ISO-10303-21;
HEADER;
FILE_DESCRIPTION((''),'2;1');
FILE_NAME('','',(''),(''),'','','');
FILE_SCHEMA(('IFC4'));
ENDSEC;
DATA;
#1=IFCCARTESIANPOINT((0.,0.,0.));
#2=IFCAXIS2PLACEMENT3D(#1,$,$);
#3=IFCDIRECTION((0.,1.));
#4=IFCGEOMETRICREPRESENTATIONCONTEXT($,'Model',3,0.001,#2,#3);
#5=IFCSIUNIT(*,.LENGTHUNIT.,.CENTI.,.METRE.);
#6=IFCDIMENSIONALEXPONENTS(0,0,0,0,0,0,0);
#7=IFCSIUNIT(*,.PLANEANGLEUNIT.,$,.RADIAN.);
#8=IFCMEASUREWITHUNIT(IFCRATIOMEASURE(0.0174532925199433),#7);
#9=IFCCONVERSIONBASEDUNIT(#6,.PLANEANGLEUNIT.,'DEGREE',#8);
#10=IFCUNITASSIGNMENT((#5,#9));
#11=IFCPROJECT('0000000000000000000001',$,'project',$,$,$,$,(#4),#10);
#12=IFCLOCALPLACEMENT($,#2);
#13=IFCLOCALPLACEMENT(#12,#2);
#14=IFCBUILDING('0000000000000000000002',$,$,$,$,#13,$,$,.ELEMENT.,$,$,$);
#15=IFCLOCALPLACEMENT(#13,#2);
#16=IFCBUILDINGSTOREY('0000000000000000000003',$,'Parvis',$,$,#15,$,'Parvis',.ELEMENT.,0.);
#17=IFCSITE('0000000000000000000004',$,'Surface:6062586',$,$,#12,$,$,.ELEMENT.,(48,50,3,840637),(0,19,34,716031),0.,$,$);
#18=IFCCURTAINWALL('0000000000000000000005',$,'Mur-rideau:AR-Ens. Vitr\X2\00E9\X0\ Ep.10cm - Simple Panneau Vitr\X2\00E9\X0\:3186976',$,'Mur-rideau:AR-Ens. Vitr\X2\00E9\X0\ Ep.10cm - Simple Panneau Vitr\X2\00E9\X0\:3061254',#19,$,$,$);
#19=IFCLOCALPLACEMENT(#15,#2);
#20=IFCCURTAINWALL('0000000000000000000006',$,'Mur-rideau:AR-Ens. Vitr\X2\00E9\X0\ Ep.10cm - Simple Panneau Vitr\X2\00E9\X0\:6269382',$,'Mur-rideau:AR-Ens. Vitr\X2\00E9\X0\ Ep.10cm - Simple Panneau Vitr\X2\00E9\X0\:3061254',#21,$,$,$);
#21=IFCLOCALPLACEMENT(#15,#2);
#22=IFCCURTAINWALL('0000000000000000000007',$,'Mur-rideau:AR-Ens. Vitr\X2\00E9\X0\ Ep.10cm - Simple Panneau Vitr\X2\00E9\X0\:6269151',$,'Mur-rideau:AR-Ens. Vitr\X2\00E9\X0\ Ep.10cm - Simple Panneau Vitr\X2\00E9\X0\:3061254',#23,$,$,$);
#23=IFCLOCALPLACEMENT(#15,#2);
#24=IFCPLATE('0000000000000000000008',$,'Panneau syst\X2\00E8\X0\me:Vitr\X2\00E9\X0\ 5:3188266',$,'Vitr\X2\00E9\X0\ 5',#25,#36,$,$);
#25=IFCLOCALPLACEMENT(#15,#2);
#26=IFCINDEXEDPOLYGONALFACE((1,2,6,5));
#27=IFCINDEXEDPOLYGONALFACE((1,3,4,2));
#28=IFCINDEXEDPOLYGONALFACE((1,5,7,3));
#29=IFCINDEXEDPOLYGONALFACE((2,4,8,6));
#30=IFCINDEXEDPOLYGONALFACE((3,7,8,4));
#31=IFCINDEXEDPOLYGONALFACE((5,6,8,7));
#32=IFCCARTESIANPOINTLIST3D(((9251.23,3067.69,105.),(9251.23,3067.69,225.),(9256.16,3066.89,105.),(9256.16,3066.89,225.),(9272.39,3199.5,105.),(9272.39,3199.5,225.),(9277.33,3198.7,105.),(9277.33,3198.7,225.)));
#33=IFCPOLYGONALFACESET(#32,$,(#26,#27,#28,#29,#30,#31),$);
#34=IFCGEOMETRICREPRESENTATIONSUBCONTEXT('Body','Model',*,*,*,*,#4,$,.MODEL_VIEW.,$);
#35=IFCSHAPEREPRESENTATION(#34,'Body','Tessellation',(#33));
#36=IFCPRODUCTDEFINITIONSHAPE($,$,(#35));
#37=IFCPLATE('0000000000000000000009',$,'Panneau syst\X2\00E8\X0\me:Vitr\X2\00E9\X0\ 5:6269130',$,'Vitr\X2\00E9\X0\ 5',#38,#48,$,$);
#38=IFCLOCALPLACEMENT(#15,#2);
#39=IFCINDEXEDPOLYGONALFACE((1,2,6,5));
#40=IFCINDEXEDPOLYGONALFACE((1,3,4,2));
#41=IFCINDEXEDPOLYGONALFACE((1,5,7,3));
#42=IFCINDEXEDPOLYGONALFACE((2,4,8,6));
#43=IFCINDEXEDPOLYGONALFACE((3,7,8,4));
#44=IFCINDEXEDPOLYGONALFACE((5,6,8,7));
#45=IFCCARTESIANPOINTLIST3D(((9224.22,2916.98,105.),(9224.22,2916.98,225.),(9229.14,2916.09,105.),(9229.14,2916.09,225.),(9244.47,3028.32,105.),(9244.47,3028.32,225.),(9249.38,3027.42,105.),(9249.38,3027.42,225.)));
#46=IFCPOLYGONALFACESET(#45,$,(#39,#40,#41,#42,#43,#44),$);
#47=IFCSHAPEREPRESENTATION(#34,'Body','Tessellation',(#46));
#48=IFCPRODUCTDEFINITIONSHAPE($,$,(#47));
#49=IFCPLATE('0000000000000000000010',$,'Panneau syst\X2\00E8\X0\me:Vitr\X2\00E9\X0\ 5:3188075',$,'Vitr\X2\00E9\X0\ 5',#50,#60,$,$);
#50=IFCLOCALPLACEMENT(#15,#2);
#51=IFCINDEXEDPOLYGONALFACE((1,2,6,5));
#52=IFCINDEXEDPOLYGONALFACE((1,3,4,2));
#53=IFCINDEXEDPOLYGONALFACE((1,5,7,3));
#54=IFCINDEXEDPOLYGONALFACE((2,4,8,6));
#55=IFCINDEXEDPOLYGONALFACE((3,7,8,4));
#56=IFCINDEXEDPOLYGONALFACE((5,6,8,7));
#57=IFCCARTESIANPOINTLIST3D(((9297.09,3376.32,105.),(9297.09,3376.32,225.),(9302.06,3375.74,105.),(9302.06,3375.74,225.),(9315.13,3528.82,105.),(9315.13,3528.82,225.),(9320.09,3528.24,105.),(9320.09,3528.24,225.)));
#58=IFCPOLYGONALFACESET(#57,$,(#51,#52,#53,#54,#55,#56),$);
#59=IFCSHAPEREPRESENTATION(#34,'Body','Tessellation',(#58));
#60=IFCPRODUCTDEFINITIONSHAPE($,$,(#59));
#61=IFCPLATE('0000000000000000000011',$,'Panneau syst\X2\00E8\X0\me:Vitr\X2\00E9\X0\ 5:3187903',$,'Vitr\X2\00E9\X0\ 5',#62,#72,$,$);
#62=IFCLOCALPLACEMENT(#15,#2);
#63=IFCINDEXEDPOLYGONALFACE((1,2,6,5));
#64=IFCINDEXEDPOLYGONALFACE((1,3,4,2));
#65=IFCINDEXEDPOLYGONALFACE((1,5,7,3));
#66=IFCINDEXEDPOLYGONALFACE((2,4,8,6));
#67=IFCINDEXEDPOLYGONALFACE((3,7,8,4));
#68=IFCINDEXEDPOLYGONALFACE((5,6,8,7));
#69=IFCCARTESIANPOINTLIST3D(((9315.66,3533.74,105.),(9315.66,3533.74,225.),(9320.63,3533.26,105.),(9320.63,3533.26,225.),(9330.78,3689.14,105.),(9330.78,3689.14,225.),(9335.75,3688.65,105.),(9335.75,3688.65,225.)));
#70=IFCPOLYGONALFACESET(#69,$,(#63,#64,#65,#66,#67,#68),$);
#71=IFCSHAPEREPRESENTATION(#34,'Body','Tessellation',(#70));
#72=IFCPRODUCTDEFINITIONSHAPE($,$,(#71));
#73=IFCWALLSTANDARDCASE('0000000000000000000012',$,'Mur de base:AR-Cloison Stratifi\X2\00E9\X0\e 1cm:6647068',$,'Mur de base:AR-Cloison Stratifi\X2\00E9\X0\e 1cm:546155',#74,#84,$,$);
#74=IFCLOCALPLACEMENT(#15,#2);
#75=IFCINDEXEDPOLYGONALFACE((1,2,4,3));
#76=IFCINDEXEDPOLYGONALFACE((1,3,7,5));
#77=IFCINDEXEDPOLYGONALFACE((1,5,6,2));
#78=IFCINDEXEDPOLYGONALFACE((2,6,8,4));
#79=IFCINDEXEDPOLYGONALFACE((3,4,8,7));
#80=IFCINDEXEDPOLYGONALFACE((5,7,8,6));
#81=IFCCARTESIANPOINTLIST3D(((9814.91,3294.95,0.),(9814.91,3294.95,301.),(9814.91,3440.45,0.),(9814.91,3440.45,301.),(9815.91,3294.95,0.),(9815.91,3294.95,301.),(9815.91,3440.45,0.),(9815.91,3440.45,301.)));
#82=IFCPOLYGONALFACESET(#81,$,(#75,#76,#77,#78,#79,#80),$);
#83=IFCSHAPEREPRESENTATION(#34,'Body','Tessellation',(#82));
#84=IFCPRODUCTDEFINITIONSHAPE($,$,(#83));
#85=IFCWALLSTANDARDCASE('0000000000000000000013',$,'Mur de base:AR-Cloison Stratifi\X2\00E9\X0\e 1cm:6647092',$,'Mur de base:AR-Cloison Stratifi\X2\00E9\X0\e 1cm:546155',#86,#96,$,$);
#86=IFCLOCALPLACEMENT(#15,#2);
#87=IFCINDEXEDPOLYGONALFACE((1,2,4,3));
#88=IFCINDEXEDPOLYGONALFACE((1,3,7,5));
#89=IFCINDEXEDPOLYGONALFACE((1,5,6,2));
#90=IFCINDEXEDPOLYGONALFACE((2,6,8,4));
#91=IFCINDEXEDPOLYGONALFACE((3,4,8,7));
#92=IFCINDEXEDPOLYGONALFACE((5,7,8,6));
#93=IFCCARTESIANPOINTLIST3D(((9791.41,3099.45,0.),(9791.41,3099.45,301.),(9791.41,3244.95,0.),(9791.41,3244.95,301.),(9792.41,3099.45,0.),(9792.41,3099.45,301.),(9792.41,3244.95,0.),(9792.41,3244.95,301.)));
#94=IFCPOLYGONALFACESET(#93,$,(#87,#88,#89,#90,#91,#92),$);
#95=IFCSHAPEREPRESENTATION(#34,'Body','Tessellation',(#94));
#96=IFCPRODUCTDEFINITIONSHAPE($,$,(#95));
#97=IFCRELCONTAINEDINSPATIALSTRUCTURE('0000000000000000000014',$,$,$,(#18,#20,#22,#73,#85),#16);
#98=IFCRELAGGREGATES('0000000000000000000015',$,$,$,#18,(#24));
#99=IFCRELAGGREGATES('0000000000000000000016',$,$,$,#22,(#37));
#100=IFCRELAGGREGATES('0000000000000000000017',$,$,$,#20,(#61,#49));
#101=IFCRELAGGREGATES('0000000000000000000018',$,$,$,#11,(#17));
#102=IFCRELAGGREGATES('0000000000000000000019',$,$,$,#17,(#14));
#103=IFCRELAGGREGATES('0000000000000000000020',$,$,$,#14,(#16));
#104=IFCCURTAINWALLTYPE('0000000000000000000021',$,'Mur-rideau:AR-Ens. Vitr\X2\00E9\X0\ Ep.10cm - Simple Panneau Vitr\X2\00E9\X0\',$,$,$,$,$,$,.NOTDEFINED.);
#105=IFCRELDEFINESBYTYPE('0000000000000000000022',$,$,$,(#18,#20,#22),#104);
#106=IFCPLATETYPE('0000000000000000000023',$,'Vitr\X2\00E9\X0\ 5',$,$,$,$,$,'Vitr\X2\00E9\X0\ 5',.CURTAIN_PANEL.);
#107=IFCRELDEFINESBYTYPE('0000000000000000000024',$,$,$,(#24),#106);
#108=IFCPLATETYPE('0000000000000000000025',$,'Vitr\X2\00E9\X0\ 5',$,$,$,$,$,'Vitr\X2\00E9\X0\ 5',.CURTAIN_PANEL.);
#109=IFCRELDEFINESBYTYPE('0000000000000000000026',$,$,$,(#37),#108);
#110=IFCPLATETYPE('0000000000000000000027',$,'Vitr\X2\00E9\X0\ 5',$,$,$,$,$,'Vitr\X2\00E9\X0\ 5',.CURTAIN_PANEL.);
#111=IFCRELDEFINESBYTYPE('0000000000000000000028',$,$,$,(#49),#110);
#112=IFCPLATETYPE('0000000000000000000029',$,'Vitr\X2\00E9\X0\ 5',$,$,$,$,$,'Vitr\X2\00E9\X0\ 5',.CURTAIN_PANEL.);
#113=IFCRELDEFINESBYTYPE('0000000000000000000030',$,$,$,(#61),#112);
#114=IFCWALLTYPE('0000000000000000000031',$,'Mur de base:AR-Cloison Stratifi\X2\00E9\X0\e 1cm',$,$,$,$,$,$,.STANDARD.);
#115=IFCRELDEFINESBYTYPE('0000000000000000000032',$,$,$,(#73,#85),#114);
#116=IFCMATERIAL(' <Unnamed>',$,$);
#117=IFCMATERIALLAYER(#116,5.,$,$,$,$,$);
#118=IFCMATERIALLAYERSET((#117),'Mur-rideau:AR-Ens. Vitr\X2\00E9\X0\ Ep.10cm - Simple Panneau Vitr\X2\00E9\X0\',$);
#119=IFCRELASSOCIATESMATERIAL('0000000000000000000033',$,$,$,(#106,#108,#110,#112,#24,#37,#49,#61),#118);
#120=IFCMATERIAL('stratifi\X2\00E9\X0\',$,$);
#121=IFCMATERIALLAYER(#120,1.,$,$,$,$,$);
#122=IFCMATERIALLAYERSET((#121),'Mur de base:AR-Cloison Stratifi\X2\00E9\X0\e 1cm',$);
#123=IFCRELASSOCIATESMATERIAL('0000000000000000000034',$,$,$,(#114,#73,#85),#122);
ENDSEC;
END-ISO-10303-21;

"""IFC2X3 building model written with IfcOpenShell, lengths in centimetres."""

from ifc_helpers import new_model, entity, si_unit, converted_unit, direction, frame, frame_2d, origin, place, context, subcontext, project, spatial, rectangle, extrude, source, transform, mapped, material, layer, layer_set, layer_usage, type_object, type_shapes, element, aggregate, save


model = new_model("IFC2X3")

# Units and contexts
model_context = context("Model", 3, precision=0.001, world=origin(), true_north=direction((0.0, 1.0)))
body_context = subcontext(model_context, "Body", "Model", "MODEL_VIEW")
ifc_project = project(units=[si_unit("LENGTHUNIT", "METRE", prefix="CENTI"), converted_unit("PLANEANGLEUNIT", "DEGREE", entity("IfcRatioMeasure", 0.0174532925199433), si_unit("PLANEANGLEUNIT", "RADIAN"), dimensions=[0, 0, 0, 0, 0, 0, 0])], contexts=[model_context])

# Site, building, storey
site_placement = place(None, origin())
site = spatial("IfcSite", under=ifc_project, at=site_placement, Name="Surface:6062586", CompositionType="ELEMENT", RefLatitude=(48, 50, 3, 840637), RefLongitude=(0, 19, 34, 716031), RefElevation=0.0)
building_placement = place(site_placement, origin())
building = spatial("IfcBuilding", under=site, at=building_placement, CompositionType="ELEMENT")
storey_placement = place(building_placement, frame((0.0, 0.0, 0.0)))
storey = spatial("IfcBuildingStorey", under=building, at=storey_placement, Name="Parvis", LongName="Parvis", CompositionType="ELEMENT", Elevation=0.0)

# Curtain walls
curtain_wall_type = type_object("IfcCurtainWallType", Name="Mur-rideau:AR-Ens. Vitré Ep.10cm - Simple Panneau Vitré", PredefinedType="NOTDEFINED")
curtain_wall_1_placement = place(storey_placement, frame((0.0, 0.0, 0.0)))
curtain_wall_1 = element("IfcCurtainWall", 1, at=curtain_wall_1_placement, inside=storey, type_object=curtain_wall_type, Name="Mur-rideau:AR-Ens. Vitré Ep.10cm - Simple Panneau Vitré:3186976", ObjectType="Mur-rideau:AR-Ens. Vitré Ep.10cm - Simple Panneau Vitré:3061254")
curtain_wall_2_placement = place(storey_placement, frame((0.0, 0.0, 0.0)))
curtain_wall_2 = element("IfcCurtainWall", 2, at=curtain_wall_2_placement, inside=storey, type_object=curtain_wall_type, Name="Mur-rideau:AR-Ens. Vitré Ep.10cm - Simple Panneau Vitré:6269382", ObjectType="Mur-rideau:AR-Ens. Vitré Ep.10cm - Simple Panneau Vitré:3061254")

# Curtain wall
curtain_wall_3_placement = place(storey_placement, frame((0.0, 0.0, 0.0)))
curtain_wall_3 = element("IfcCurtainWall", 3, at=curtain_wall_3_placement, inside=storey, type_object=curtain_wall_type, Name="Mur-rideau:AR-Ens. Vitré Ep.10cm - Simple Panneau Vitré:6269151", ObjectType="Mur-rideau:AR-Ens. Vitré Ep.10cm - Simple Panneau Vitré:3061254")

# Plates
ifc_material_1 = material(Name=" <Unnamed>")
ifc_layer_1 = layer(ifc_material_1, 5.0)
ifc_layer_set_1 = layer_set([ifc_layer_1], Name="Mur-rideau:AR-Ens. Vitré Ep.10cm - Simple Panneau Vitré")
ifc_layer_usage_1 = layer_usage(ifc_layer_set_1, "AXIS3", "POSITIVE", 0.0)
plate_type_1 = type_object("IfcPlateType", Name="Vitré 5", ElementType="Vitré 5", PredefinedType="CURTAIN_PANEL", material=ifc_layer_set_1)
shared_shape_1 = source(origin(), body_context, "Body", "SweptSolid", [
    extrude(rectangle(XDim=5.0, YDim=133.5, at=frame_2d((0.0, 0.0), x_axis=(1.0, 0.0))), frame((0.0, 0.0, 0.0), z_axis=(0.0, 0.0, 1.0), x_axis=(0.0, 1.0, 0.0)), (0.0, 0.0, 1.0), 120.0),
])
type_shapes(plate_type_1, [shared_shape_1])
plate_1_placement = place(curtain_wall_1_placement, frame((9264.28, 3133.2, 105.0), z_axis=(0.0, 0.0, 1.0), x_axis=(-0.158533, -0.987354, 0.0)))
plate_1 = element("IfcPlate", 4, at=plate_1_placement, type_object=plate_type_1, material=ifc_layer_usage_1, Name="Panneau système:Vitré 5:3188266", ObjectType="Vitré 5", context=body_context, shape_type="MappedRepresentation", body=[
    mapped(shared_shape_1, transform((0.0, 0.0, 0.0), scale=1.0)),
])
aggregate(curtain_wall_1, [plate_1])
ifc_layer_usage_2 = layer_usage(ifc_layer_set_1, "AXIS3", "POSITIVE", 0.0)
plate_type_2 = type_object("IfcPlateType", Name="Vitré 5", ElementType="Vitré 5", PredefinedType="CURTAIN_PANEL", material=ifc_layer_set_1)
shared_shape_2 = source(origin(), body_context, "Body", "SweptSolid", [
    extrude(rectangle(XDim=5.0, YDim=113.16, at=frame_2d((0.0, 0.0), x_axis=(1.0, 0.0))), frame((0.0, 0.0, 0.0), z_axis=(0.0, 0.0, 1.0), x_axis=(0.0, 1.0, 0.0)), (0.0, 0.0, 1.0), 120.0),
])
type_shapes(plate_type_2, [shared_shape_2])
plate_2_placement = place(curtain_wall_3_placement, frame((9236.8, 2972.2, 105.0), z_axis=(0.0, 0.0, 1.0), x_axis=(-0.17894, -0.98386, 0.0)))
plate_2 = element("IfcPlate", 5, at=plate_2_placement, type_object=plate_type_2, material=ifc_layer_usage_2, Name="Panneau système:Vitré 5:6269130", ObjectType="Vitré 5", context=body_context, shape_type="MappedRepresentation", body=[
    mapped(shared_shape_2, transform((0.0, 0.0, 0.0), scale=1.0)),
])
aggregate(curtain_wall_3, [plate_2])
ifc_layer_usage_3 = layer_usage(ifc_layer_set_1, "AXIS3", "POSITIVE", 0.0)
plate_type_3 = type_object("IfcPlateType", Name="Vitré 5", ElementType="Vitré 5", PredefinedType="CURTAIN_PANEL", material=ifc_layer_set_1)
shared_shape_3 = source(origin(), body_context, "Body", "SweptSolid", [
    extrude(rectangle(XDim=5.0, YDim=153.56, at=frame_2d((0.0, 0.0), x_axis=(1.0, 0.0))), frame((0.0, 0.0, 0.0), z_axis=(0.0, 0.0, 1.0), x_axis=(0.0, 1.0, 0.0)), (0.0, 0.0, 1.0), 120.0),
])
type_shapes(plate_type_3, [shared_shape_3])
plate_3_placement = place(curtain_wall_2_placement, frame((9308.59, 3452.28, 105.0), z_axis=(0.0, 0.0, 1.0), x_axis=(-0.117457, -0.993078, 0.0)))
plate_3 = element("IfcPlate", 6, at=plate_3_placement, type_object=plate_type_3, material=ifc_layer_usage_3, Name="Panneau système:Vitré 5:3188075", ObjectType="Vitré 5", context=body_context, shape_type="MappedRepresentation", body=[
    mapped(shared_shape_3, transform((0.0, 0.0, 0.0), scale=1.0)),
])
ifc_layer_usage_4 = layer_usage(ifc_layer_set_1, "AXIS3", "POSITIVE", 0.0)
plate_type_4 = type_object("IfcPlateType", Name="Vitré 5", ElementType="Vitré 5", PredefinedType="CURTAIN_PANEL", material=ifc_layer_set_1)
shared_shape_4 = source(origin(), body_context, "Body", "SweptSolid", [
    extrude(rectangle(XDim=5.0, YDim=156.13, at=frame_2d((0.0, 0.0), x_axis=(1.0, 0.0))), frame((0.0, 0.0, 0.0), z_axis=(0.0, 0.0, 1.0), x_axis=(0.0, 1.0, 0.0)), (0.0, 0.0, 1.0), 120.0),
])
type_shapes(plate_type_4, [shared_shape_4])
plate_4_placement = place(curtain_wall_2_placement, frame((9325.71, 3611.2, 105.0), z_axis=(0.0, 0.0, 1.0), x_axis=(-0.096838, -0.9953, 0.0)))
plate_4 = element("IfcPlate", 7, at=plate_4_placement, type_object=plate_type_4, material=ifc_layer_usage_4, Name="Panneau système:Vitré 5:3187903", ObjectType="Vitré 5", context=body_context, shape_type="MappedRepresentation", body=[
    mapped(shared_shape_4, transform((0.0, 0.0, 0.0), scale=1.0)),
])
aggregate(curtain_wall_2, [plate_4, plate_3])

# Walls
ifc_material_2 = material(Name="stratifié")
ifc_layer_2 = layer(ifc_material_2, 1.0)
ifc_layer_set_2 = layer_set([ifc_layer_2], Name="Mur de base:AR-Cloison Stratifiée 1cm")
ifc_layer_usage_5 = layer_usage(ifc_layer_set_2, "AXIS2", "NEGATIVE", 0.5)
wall_type_1 = type_object("IfcWallType", Name="Mur de base:AR-Cloison Stratifiée 1cm", PredefinedType="STANDARD", material=ifc_layer_set_2)
wall_1_placement = place(storey_placement, frame((9815.41, 3294.95, 0.0), z_axis=(0.0, 0.0, 1.0), x_axis=(0.0, 1.0, 0.0)))
element("IfcWallStandardCase", 8, at=wall_1_placement, inside=storey, type_object=wall_type_1, material=ifc_layer_usage_5, Name="Mur de base:AR-Cloison Stratifiée 1cm:6647068", ObjectType="Mur de base:AR-Cloison Stratifiée 1cm:546155", context=body_context, shape_type="SweptSolid", body=[
    extrude(rectangle(XDim=145.5, YDim=1.0, at=frame_2d((72.75, 0.0), x_axis=(-1.0, 0.0))), origin(), (0.0, 0.0, 1.0), 301.0),
])
ifc_layer_usage_6 = layer_usage(ifc_layer_set_2, "AXIS2", "POSITIVE", -0.5)
wall_2_placement = place(storey_placement, frame((9791.91, 3244.95, 0.0), z_axis=(0.0, 0.0, 1.0), x_axis=(0.0, -1.0, 0.0)))
element("IfcWallStandardCase", 9, at=wall_2_placement, inside=storey, type_object=wall_type_1, material=ifc_layer_usage_6, Name="Mur de base:AR-Cloison Stratifiée 1cm:6647092", ObjectType="Mur de base:AR-Cloison Stratifiée 1cm:546155", context=body_context, shape_type="SweptSolid", body=[
    extrude(rectangle(XDim=145.5, YDim=1.0, at=frame_2d((72.75, 0.0), x_axis=(-1.0, 0.0))), origin(), (0.0, 0.0, 1.0), 301.0),
])

save(model, "model.ifc")
